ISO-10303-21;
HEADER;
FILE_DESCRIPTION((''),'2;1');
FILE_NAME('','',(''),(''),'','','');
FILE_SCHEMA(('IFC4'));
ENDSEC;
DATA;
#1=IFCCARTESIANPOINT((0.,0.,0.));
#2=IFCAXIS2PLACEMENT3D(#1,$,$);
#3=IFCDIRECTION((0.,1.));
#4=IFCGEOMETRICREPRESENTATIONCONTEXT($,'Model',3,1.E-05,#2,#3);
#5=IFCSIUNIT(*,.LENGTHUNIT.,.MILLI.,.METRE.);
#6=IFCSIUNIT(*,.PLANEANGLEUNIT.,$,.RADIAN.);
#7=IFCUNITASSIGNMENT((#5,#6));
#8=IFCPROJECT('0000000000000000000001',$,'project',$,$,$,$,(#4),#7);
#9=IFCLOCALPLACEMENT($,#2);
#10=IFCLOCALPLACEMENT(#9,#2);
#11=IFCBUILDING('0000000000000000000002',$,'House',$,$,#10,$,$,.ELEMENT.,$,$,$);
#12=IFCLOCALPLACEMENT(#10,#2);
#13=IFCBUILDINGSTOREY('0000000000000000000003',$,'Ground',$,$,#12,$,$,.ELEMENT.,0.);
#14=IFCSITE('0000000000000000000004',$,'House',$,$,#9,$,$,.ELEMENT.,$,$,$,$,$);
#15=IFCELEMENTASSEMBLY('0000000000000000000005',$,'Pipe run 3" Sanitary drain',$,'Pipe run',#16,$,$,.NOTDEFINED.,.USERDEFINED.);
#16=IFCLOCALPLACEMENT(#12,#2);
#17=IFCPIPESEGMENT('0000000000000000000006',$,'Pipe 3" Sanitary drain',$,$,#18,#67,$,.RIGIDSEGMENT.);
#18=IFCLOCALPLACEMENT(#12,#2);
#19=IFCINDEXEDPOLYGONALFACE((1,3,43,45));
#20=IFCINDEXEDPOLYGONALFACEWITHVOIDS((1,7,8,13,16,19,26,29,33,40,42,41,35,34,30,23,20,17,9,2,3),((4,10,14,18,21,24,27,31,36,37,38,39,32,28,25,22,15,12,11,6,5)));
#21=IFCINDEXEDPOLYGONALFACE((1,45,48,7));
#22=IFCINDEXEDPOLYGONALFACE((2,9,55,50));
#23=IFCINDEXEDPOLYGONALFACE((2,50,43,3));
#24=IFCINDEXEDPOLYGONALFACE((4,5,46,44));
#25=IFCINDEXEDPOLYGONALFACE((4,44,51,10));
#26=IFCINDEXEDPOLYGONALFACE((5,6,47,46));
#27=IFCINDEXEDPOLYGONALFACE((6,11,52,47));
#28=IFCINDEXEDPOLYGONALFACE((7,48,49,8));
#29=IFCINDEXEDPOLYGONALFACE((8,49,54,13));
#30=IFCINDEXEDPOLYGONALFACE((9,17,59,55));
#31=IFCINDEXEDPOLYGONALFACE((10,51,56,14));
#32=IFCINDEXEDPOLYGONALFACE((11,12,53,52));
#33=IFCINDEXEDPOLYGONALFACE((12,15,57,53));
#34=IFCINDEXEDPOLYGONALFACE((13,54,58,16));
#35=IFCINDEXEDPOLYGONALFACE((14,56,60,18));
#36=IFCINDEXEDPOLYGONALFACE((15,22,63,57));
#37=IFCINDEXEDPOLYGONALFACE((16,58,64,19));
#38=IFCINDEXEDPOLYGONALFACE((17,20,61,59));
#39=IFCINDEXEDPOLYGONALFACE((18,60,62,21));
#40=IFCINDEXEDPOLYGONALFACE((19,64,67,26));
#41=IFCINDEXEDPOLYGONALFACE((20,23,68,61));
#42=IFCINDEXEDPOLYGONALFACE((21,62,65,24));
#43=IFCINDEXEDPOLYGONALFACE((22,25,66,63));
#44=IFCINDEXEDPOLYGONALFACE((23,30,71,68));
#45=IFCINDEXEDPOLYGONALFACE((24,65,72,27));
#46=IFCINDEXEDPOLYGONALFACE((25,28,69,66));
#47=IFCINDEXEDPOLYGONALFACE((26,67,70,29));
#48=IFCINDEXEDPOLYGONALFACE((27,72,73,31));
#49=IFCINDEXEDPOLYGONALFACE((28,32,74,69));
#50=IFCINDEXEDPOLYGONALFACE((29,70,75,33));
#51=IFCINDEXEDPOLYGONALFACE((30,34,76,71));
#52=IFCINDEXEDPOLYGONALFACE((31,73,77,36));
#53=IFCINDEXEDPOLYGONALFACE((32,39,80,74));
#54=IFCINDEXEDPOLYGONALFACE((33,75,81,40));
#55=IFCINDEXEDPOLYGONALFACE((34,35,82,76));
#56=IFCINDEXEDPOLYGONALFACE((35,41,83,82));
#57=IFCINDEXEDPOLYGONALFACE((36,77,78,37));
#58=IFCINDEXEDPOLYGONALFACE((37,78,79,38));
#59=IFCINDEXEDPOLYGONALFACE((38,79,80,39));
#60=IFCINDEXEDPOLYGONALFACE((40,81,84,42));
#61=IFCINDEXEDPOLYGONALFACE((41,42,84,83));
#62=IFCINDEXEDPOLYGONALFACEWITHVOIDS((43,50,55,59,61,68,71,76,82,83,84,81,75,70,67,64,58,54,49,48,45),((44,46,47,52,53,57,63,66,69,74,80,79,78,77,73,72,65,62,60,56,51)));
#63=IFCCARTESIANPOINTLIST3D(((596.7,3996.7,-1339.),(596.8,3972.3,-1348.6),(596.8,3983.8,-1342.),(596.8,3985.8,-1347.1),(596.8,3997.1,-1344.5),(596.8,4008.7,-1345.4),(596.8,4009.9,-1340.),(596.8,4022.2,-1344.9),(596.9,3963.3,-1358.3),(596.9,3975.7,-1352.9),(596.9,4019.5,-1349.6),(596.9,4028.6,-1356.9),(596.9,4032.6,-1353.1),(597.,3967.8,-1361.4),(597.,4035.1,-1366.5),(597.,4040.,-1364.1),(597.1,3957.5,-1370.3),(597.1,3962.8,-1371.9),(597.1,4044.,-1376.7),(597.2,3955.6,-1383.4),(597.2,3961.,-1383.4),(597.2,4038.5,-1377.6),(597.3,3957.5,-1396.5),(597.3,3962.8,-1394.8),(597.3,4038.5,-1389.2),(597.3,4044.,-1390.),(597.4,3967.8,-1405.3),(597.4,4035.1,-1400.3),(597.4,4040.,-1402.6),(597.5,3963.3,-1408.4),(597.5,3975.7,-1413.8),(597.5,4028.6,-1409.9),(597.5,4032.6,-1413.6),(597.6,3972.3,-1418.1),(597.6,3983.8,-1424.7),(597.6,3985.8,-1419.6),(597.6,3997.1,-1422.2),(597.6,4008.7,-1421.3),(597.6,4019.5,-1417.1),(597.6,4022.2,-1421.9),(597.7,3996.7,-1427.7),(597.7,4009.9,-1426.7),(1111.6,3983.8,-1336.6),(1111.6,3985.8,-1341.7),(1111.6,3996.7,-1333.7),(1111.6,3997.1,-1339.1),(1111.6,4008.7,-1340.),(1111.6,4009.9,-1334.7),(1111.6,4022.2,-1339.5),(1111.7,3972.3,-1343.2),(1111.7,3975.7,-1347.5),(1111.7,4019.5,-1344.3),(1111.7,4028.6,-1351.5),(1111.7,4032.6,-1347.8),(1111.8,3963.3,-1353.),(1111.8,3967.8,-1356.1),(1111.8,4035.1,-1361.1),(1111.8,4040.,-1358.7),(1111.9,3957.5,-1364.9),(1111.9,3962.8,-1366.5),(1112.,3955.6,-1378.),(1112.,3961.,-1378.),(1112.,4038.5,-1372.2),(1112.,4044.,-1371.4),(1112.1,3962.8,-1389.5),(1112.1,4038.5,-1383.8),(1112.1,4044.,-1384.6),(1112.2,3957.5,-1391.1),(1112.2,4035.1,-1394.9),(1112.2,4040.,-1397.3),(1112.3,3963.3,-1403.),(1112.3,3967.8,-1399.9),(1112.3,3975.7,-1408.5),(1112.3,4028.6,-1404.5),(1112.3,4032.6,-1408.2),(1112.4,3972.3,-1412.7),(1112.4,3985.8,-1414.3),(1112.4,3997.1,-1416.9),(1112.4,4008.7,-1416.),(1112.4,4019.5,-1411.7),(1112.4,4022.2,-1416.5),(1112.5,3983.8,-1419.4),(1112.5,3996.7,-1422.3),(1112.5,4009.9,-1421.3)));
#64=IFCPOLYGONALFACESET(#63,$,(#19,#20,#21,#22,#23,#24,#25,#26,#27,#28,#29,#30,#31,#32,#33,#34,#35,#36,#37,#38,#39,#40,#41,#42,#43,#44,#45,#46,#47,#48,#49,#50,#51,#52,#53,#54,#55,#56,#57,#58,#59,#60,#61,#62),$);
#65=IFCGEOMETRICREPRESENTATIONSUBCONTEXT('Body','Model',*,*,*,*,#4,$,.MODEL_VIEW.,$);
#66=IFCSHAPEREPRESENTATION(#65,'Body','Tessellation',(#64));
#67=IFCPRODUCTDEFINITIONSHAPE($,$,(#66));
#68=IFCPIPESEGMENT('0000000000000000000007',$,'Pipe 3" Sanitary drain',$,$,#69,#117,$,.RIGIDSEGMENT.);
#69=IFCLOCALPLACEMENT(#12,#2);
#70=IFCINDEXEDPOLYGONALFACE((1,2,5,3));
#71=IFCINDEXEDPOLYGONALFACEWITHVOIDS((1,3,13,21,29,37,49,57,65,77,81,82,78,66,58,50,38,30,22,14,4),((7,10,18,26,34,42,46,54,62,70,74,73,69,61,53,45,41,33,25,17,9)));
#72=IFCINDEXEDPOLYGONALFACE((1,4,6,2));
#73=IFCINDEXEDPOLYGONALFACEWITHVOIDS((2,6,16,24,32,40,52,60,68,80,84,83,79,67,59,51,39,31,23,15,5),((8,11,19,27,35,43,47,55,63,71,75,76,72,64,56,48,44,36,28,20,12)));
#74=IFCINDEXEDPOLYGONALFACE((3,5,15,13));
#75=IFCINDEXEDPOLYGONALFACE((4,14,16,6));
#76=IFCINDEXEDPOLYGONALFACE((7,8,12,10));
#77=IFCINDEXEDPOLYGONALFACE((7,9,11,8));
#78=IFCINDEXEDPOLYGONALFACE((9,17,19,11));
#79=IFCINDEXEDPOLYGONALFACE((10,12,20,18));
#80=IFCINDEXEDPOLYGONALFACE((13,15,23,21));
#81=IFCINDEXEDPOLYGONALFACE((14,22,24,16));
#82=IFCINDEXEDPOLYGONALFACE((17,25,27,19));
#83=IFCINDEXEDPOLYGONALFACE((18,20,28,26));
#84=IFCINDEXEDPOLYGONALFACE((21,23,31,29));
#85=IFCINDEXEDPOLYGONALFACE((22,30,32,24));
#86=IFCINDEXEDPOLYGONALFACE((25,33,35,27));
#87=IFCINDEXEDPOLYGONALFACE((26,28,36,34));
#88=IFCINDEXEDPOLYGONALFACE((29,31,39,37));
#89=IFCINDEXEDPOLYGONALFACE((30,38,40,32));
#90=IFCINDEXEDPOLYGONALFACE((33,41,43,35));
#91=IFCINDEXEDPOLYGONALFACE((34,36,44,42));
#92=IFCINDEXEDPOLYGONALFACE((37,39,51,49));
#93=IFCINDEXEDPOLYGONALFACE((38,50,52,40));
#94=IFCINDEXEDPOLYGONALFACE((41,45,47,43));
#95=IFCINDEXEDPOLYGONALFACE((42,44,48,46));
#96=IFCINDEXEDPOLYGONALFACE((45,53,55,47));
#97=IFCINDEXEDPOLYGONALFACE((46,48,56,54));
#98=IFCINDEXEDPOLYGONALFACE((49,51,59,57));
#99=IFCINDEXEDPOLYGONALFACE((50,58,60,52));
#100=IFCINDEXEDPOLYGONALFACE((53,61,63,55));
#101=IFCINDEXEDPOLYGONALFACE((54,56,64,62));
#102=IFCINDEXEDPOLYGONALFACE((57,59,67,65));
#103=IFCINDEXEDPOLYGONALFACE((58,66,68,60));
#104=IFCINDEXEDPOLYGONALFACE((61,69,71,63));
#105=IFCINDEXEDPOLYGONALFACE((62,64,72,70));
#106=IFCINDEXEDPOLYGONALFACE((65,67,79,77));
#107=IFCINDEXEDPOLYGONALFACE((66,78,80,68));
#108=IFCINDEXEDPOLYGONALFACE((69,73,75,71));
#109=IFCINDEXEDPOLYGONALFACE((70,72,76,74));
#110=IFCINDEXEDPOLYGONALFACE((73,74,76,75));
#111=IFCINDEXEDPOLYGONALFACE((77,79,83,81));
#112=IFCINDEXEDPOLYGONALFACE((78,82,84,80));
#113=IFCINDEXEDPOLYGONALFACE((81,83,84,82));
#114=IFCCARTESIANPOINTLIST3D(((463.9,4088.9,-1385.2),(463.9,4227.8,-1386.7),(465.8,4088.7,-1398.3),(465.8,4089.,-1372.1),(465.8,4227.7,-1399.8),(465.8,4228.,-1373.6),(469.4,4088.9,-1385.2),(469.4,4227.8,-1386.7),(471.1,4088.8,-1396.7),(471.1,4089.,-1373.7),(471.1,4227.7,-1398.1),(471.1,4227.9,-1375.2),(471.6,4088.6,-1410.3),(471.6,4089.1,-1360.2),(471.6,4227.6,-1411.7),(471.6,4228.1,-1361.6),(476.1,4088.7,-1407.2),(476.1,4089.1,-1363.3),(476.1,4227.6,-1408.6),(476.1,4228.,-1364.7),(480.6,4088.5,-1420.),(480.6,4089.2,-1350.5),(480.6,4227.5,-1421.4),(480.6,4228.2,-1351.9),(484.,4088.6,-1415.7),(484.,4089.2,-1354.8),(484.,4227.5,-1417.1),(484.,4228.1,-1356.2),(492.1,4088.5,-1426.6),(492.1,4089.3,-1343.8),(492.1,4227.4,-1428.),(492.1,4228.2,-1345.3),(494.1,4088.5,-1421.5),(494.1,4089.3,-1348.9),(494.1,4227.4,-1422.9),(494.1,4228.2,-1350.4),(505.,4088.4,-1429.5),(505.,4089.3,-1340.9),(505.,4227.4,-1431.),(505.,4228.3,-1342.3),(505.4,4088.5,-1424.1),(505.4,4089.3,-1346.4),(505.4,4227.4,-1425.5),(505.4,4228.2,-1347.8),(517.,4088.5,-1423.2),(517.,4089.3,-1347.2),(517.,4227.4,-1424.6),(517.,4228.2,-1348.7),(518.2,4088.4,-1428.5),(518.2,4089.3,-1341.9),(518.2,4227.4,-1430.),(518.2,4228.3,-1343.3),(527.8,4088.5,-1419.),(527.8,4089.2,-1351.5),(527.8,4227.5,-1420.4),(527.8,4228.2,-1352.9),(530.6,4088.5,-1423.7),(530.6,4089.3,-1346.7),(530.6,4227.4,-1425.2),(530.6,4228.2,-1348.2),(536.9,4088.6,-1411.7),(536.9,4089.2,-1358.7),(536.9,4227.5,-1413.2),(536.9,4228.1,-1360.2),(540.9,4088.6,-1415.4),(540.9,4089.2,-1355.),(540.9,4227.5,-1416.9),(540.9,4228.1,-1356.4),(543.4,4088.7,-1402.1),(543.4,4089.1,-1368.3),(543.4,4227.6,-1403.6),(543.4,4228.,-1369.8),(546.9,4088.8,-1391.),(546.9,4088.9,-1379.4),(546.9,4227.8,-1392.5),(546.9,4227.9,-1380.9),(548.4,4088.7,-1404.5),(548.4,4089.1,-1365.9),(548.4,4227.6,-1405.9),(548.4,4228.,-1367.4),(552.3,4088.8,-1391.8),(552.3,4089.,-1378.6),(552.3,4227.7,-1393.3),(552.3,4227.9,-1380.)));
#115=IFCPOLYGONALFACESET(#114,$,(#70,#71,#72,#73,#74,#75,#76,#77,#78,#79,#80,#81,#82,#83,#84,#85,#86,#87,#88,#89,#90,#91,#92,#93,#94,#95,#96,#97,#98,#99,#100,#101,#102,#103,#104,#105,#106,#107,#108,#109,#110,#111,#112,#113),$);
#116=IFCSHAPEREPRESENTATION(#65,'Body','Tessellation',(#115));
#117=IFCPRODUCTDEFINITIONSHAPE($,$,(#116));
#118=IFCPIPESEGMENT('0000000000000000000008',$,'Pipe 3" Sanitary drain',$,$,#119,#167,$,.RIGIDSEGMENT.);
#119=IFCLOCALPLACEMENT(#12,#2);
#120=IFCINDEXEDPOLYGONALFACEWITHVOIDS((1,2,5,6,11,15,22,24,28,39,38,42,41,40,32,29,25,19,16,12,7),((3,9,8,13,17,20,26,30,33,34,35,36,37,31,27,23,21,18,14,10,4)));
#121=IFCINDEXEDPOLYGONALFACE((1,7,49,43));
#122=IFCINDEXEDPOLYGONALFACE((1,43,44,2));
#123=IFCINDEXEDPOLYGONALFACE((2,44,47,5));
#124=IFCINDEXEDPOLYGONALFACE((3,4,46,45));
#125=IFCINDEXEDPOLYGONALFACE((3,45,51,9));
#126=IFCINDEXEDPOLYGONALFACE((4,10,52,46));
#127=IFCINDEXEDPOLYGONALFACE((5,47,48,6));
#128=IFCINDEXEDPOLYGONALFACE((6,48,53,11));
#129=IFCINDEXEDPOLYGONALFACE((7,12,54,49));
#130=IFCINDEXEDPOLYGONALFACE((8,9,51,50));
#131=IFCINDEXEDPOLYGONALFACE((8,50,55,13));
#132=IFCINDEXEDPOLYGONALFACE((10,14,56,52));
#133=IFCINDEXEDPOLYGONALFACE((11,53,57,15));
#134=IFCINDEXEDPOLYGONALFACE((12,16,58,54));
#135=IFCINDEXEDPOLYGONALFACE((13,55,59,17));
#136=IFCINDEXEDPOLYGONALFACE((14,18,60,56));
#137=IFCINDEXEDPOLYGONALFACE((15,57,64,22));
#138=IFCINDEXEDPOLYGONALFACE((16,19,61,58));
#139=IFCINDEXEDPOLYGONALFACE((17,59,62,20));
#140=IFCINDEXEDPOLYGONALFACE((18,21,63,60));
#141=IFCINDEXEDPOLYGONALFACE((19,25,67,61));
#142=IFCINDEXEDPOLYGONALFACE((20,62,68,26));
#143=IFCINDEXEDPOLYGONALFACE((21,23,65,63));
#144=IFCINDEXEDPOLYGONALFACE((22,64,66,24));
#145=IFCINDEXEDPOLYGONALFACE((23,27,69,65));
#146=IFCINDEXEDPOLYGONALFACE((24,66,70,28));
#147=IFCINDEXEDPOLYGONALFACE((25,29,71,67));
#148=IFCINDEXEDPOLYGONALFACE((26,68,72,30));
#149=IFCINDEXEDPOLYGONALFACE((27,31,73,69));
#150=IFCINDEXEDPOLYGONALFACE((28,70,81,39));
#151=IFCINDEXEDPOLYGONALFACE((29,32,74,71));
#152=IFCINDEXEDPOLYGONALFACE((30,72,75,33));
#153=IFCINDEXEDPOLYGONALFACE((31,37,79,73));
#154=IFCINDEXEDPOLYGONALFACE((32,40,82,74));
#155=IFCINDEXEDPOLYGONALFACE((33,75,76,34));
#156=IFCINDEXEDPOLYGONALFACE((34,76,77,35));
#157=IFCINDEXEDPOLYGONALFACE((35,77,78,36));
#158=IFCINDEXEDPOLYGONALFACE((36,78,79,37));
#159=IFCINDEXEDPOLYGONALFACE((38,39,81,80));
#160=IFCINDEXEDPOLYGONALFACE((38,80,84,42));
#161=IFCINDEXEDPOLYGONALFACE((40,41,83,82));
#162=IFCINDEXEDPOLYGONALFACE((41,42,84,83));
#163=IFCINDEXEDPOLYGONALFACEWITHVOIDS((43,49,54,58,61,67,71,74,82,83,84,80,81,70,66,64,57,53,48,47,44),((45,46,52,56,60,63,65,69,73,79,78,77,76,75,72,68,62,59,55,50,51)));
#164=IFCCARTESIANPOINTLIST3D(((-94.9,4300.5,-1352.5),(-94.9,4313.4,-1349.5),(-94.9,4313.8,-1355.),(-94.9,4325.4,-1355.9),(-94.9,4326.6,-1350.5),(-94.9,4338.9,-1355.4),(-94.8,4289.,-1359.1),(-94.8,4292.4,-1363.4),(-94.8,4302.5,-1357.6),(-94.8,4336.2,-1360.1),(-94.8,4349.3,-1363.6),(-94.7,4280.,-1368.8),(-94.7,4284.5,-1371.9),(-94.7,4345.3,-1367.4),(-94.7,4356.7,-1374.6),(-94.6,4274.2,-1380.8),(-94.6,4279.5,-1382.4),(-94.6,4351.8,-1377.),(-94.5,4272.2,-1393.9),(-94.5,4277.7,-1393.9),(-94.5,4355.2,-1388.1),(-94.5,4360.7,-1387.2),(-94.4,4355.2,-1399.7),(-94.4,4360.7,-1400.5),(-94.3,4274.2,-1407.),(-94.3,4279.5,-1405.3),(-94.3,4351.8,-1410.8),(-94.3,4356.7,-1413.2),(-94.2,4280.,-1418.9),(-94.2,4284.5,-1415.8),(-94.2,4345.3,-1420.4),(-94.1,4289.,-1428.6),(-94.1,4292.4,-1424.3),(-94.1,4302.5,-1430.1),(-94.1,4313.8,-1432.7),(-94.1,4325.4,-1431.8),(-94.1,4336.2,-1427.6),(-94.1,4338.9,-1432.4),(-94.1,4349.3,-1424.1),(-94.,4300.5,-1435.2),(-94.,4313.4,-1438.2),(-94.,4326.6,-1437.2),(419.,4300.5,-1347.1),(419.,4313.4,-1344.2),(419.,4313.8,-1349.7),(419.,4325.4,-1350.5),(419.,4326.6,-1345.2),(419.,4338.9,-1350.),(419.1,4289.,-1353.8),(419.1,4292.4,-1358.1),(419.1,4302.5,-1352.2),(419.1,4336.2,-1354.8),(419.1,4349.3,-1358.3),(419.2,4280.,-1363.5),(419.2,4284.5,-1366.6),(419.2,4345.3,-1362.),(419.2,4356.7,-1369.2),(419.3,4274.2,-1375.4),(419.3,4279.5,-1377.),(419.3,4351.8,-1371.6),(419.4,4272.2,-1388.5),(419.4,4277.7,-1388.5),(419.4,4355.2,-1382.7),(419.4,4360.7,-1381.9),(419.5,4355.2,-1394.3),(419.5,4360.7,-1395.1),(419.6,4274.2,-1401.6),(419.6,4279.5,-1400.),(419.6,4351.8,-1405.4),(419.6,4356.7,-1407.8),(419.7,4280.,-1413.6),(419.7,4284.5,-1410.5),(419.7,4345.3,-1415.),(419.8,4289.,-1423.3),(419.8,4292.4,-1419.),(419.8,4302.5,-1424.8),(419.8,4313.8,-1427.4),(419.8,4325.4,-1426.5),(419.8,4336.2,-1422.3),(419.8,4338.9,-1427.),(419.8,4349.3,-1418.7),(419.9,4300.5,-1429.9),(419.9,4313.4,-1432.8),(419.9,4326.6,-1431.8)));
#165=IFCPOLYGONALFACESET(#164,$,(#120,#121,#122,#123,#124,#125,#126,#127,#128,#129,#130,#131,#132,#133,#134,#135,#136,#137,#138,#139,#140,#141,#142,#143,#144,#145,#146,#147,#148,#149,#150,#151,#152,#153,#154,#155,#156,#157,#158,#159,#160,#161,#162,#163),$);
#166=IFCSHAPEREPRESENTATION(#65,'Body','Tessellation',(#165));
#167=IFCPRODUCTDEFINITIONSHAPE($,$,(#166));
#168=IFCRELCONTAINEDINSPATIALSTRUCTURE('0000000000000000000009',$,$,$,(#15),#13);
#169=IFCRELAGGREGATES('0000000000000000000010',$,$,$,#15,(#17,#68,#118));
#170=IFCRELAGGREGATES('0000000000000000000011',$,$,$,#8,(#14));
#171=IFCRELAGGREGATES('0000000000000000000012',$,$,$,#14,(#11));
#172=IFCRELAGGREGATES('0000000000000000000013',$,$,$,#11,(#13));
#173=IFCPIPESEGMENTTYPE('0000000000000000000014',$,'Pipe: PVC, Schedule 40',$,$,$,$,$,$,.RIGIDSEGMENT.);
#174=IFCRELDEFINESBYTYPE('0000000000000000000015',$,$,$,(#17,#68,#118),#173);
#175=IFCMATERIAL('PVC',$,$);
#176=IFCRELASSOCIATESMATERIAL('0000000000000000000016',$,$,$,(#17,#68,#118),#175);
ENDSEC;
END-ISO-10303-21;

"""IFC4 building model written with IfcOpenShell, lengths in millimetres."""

from ifc_helpers import new_model, si_unit, direction, frame, origin, origin_with_axes, origin_2d, place, context, subcontext, project, spatial, hollow_circle, extrude, material, type_object, element, aggregate, save


model = new_model("IFC4")

# Units and contexts
model_context = context("Model", 3, precision=1e-05, world=origin(), true_north=direction((0.0, 1.0)))
body_context = subcontext(model_context, "Body", "Model", "MODEL_VIEW")
ifc_project = project(units=[si_unit("LENGTHUNIT", "METRE", prefix="MILLI"), si_unit("PLANEANGLEUNIT", "RADIAN")], contexts=[model_context])

# Site, building, storey
site_placement = place(None, origin())
site = spatial("IfcSite", under=ifc_project, at=site_placement, Name="House", CompositionType="ELEMENT")
building_placement = place(site_placement, origin())
building = spatial("IfcBuilding", under=site, at=building_placement, Name="House", CompositionType="ELEMENT")
storey_placement = place(building_placement, origin())
storey = spatial("IfcBuildingStorey", under=building, at=storey_placement, Name="Ground", CompositionType="ELEMENT", Elevation=0.0)

# Element assembly, pipe segments
assembly_1_placement = place(storey_placement, origin_with_axes())
assembly_1 = element("IfcElementAssembly", 1, at=assembly_1_placement, inside=storey, Name="Pipe run 3\" Sanitary drain", ObjectType="Pipe run", AssemblyPlace="NOTDEFINED", PredefinedType="USERDEFINED")
ifc_material = material(Name="PVC")
pipe_segment_type = type_object("IfcPipeSegmentType", Name="Pipe: PVC, Schedule 40", PredefinedType="RIGIDSEGMENT")
pipe_segment_1_placement = place(storey_placement, origin_with_axes())
pipe_segment_1 = element("IfcPipeSegment", 2, at=pipe_segment_1_placement, type_object=pipe_segment_type, material=ifc_material, Name="Pipe 3\" Sanitary drain", PredefinedType="RIGIDSEGMENT", context=body_context, shape_type="SweptSolid", body=[
    extrude(hollow_circle(Radius=44.5, WallThickness=5.5, at=origin_2d()), frame((1112.0, 4000.0, -1378.0), z_axis=(-0.999946, 0.0, -0.010416), x_axis=(0.0, -1.0, 0.0)), (0.0, 0.0, 1.0), 514.8),
])
pipe_segment_2_placement = place(storey_placement, origin_with_axes())
pipe_segment_2 = element("IfcPipeSegment", 3, at=pipe_segment_2_placement, type_object=pipe_segment_type, material=ifc_material, Name="Pipe 3\" Sanitary drain", PredefinedType="RIGIDSEGMENT", context=body_context, shape_type="SweptSolid", body=[
    extrude(hollow_circle(Radius=44.5, WallThickness=5.5, at=origin_2d()), frame((508.3, 4088.9, -1385.2), z_axis=(0.0, 0.999946, -0.010416), x_axis=(-1.0, 0.0, 0.0)), (0.0, 0.0, 1.0), 138.9),
])
pipe_segment_3_placement = place(storey_placement, origin_with_axes())
pipe_segment_3 = element("IfcPipeSegment", 4, at=pipe_segment_3_placement, type_object=pipe_segment_type, material=ifc_material, Name="Pipe 3\" Sanitary drain", PredefinedType="RIGIDSEGMENT", context=body_context, shape_type="SweptSolid", body=[
    extrude(hollow_circle(Radius=44.5, WallThickness=5.5, at=origin_2d()), frame((419.4, 4316.7, -1388.5), z_axis=(-0.999946, 0.0, -0.010416), x_axis=(0.0, -1.0, 0.0)), (0.0, 0.0, 1.0), 513.9),
])

aggregate(assembly_1, [pipe_segment_1, pipe_segment_2, pipe_segment_3])

save(model, "model.ifc")
